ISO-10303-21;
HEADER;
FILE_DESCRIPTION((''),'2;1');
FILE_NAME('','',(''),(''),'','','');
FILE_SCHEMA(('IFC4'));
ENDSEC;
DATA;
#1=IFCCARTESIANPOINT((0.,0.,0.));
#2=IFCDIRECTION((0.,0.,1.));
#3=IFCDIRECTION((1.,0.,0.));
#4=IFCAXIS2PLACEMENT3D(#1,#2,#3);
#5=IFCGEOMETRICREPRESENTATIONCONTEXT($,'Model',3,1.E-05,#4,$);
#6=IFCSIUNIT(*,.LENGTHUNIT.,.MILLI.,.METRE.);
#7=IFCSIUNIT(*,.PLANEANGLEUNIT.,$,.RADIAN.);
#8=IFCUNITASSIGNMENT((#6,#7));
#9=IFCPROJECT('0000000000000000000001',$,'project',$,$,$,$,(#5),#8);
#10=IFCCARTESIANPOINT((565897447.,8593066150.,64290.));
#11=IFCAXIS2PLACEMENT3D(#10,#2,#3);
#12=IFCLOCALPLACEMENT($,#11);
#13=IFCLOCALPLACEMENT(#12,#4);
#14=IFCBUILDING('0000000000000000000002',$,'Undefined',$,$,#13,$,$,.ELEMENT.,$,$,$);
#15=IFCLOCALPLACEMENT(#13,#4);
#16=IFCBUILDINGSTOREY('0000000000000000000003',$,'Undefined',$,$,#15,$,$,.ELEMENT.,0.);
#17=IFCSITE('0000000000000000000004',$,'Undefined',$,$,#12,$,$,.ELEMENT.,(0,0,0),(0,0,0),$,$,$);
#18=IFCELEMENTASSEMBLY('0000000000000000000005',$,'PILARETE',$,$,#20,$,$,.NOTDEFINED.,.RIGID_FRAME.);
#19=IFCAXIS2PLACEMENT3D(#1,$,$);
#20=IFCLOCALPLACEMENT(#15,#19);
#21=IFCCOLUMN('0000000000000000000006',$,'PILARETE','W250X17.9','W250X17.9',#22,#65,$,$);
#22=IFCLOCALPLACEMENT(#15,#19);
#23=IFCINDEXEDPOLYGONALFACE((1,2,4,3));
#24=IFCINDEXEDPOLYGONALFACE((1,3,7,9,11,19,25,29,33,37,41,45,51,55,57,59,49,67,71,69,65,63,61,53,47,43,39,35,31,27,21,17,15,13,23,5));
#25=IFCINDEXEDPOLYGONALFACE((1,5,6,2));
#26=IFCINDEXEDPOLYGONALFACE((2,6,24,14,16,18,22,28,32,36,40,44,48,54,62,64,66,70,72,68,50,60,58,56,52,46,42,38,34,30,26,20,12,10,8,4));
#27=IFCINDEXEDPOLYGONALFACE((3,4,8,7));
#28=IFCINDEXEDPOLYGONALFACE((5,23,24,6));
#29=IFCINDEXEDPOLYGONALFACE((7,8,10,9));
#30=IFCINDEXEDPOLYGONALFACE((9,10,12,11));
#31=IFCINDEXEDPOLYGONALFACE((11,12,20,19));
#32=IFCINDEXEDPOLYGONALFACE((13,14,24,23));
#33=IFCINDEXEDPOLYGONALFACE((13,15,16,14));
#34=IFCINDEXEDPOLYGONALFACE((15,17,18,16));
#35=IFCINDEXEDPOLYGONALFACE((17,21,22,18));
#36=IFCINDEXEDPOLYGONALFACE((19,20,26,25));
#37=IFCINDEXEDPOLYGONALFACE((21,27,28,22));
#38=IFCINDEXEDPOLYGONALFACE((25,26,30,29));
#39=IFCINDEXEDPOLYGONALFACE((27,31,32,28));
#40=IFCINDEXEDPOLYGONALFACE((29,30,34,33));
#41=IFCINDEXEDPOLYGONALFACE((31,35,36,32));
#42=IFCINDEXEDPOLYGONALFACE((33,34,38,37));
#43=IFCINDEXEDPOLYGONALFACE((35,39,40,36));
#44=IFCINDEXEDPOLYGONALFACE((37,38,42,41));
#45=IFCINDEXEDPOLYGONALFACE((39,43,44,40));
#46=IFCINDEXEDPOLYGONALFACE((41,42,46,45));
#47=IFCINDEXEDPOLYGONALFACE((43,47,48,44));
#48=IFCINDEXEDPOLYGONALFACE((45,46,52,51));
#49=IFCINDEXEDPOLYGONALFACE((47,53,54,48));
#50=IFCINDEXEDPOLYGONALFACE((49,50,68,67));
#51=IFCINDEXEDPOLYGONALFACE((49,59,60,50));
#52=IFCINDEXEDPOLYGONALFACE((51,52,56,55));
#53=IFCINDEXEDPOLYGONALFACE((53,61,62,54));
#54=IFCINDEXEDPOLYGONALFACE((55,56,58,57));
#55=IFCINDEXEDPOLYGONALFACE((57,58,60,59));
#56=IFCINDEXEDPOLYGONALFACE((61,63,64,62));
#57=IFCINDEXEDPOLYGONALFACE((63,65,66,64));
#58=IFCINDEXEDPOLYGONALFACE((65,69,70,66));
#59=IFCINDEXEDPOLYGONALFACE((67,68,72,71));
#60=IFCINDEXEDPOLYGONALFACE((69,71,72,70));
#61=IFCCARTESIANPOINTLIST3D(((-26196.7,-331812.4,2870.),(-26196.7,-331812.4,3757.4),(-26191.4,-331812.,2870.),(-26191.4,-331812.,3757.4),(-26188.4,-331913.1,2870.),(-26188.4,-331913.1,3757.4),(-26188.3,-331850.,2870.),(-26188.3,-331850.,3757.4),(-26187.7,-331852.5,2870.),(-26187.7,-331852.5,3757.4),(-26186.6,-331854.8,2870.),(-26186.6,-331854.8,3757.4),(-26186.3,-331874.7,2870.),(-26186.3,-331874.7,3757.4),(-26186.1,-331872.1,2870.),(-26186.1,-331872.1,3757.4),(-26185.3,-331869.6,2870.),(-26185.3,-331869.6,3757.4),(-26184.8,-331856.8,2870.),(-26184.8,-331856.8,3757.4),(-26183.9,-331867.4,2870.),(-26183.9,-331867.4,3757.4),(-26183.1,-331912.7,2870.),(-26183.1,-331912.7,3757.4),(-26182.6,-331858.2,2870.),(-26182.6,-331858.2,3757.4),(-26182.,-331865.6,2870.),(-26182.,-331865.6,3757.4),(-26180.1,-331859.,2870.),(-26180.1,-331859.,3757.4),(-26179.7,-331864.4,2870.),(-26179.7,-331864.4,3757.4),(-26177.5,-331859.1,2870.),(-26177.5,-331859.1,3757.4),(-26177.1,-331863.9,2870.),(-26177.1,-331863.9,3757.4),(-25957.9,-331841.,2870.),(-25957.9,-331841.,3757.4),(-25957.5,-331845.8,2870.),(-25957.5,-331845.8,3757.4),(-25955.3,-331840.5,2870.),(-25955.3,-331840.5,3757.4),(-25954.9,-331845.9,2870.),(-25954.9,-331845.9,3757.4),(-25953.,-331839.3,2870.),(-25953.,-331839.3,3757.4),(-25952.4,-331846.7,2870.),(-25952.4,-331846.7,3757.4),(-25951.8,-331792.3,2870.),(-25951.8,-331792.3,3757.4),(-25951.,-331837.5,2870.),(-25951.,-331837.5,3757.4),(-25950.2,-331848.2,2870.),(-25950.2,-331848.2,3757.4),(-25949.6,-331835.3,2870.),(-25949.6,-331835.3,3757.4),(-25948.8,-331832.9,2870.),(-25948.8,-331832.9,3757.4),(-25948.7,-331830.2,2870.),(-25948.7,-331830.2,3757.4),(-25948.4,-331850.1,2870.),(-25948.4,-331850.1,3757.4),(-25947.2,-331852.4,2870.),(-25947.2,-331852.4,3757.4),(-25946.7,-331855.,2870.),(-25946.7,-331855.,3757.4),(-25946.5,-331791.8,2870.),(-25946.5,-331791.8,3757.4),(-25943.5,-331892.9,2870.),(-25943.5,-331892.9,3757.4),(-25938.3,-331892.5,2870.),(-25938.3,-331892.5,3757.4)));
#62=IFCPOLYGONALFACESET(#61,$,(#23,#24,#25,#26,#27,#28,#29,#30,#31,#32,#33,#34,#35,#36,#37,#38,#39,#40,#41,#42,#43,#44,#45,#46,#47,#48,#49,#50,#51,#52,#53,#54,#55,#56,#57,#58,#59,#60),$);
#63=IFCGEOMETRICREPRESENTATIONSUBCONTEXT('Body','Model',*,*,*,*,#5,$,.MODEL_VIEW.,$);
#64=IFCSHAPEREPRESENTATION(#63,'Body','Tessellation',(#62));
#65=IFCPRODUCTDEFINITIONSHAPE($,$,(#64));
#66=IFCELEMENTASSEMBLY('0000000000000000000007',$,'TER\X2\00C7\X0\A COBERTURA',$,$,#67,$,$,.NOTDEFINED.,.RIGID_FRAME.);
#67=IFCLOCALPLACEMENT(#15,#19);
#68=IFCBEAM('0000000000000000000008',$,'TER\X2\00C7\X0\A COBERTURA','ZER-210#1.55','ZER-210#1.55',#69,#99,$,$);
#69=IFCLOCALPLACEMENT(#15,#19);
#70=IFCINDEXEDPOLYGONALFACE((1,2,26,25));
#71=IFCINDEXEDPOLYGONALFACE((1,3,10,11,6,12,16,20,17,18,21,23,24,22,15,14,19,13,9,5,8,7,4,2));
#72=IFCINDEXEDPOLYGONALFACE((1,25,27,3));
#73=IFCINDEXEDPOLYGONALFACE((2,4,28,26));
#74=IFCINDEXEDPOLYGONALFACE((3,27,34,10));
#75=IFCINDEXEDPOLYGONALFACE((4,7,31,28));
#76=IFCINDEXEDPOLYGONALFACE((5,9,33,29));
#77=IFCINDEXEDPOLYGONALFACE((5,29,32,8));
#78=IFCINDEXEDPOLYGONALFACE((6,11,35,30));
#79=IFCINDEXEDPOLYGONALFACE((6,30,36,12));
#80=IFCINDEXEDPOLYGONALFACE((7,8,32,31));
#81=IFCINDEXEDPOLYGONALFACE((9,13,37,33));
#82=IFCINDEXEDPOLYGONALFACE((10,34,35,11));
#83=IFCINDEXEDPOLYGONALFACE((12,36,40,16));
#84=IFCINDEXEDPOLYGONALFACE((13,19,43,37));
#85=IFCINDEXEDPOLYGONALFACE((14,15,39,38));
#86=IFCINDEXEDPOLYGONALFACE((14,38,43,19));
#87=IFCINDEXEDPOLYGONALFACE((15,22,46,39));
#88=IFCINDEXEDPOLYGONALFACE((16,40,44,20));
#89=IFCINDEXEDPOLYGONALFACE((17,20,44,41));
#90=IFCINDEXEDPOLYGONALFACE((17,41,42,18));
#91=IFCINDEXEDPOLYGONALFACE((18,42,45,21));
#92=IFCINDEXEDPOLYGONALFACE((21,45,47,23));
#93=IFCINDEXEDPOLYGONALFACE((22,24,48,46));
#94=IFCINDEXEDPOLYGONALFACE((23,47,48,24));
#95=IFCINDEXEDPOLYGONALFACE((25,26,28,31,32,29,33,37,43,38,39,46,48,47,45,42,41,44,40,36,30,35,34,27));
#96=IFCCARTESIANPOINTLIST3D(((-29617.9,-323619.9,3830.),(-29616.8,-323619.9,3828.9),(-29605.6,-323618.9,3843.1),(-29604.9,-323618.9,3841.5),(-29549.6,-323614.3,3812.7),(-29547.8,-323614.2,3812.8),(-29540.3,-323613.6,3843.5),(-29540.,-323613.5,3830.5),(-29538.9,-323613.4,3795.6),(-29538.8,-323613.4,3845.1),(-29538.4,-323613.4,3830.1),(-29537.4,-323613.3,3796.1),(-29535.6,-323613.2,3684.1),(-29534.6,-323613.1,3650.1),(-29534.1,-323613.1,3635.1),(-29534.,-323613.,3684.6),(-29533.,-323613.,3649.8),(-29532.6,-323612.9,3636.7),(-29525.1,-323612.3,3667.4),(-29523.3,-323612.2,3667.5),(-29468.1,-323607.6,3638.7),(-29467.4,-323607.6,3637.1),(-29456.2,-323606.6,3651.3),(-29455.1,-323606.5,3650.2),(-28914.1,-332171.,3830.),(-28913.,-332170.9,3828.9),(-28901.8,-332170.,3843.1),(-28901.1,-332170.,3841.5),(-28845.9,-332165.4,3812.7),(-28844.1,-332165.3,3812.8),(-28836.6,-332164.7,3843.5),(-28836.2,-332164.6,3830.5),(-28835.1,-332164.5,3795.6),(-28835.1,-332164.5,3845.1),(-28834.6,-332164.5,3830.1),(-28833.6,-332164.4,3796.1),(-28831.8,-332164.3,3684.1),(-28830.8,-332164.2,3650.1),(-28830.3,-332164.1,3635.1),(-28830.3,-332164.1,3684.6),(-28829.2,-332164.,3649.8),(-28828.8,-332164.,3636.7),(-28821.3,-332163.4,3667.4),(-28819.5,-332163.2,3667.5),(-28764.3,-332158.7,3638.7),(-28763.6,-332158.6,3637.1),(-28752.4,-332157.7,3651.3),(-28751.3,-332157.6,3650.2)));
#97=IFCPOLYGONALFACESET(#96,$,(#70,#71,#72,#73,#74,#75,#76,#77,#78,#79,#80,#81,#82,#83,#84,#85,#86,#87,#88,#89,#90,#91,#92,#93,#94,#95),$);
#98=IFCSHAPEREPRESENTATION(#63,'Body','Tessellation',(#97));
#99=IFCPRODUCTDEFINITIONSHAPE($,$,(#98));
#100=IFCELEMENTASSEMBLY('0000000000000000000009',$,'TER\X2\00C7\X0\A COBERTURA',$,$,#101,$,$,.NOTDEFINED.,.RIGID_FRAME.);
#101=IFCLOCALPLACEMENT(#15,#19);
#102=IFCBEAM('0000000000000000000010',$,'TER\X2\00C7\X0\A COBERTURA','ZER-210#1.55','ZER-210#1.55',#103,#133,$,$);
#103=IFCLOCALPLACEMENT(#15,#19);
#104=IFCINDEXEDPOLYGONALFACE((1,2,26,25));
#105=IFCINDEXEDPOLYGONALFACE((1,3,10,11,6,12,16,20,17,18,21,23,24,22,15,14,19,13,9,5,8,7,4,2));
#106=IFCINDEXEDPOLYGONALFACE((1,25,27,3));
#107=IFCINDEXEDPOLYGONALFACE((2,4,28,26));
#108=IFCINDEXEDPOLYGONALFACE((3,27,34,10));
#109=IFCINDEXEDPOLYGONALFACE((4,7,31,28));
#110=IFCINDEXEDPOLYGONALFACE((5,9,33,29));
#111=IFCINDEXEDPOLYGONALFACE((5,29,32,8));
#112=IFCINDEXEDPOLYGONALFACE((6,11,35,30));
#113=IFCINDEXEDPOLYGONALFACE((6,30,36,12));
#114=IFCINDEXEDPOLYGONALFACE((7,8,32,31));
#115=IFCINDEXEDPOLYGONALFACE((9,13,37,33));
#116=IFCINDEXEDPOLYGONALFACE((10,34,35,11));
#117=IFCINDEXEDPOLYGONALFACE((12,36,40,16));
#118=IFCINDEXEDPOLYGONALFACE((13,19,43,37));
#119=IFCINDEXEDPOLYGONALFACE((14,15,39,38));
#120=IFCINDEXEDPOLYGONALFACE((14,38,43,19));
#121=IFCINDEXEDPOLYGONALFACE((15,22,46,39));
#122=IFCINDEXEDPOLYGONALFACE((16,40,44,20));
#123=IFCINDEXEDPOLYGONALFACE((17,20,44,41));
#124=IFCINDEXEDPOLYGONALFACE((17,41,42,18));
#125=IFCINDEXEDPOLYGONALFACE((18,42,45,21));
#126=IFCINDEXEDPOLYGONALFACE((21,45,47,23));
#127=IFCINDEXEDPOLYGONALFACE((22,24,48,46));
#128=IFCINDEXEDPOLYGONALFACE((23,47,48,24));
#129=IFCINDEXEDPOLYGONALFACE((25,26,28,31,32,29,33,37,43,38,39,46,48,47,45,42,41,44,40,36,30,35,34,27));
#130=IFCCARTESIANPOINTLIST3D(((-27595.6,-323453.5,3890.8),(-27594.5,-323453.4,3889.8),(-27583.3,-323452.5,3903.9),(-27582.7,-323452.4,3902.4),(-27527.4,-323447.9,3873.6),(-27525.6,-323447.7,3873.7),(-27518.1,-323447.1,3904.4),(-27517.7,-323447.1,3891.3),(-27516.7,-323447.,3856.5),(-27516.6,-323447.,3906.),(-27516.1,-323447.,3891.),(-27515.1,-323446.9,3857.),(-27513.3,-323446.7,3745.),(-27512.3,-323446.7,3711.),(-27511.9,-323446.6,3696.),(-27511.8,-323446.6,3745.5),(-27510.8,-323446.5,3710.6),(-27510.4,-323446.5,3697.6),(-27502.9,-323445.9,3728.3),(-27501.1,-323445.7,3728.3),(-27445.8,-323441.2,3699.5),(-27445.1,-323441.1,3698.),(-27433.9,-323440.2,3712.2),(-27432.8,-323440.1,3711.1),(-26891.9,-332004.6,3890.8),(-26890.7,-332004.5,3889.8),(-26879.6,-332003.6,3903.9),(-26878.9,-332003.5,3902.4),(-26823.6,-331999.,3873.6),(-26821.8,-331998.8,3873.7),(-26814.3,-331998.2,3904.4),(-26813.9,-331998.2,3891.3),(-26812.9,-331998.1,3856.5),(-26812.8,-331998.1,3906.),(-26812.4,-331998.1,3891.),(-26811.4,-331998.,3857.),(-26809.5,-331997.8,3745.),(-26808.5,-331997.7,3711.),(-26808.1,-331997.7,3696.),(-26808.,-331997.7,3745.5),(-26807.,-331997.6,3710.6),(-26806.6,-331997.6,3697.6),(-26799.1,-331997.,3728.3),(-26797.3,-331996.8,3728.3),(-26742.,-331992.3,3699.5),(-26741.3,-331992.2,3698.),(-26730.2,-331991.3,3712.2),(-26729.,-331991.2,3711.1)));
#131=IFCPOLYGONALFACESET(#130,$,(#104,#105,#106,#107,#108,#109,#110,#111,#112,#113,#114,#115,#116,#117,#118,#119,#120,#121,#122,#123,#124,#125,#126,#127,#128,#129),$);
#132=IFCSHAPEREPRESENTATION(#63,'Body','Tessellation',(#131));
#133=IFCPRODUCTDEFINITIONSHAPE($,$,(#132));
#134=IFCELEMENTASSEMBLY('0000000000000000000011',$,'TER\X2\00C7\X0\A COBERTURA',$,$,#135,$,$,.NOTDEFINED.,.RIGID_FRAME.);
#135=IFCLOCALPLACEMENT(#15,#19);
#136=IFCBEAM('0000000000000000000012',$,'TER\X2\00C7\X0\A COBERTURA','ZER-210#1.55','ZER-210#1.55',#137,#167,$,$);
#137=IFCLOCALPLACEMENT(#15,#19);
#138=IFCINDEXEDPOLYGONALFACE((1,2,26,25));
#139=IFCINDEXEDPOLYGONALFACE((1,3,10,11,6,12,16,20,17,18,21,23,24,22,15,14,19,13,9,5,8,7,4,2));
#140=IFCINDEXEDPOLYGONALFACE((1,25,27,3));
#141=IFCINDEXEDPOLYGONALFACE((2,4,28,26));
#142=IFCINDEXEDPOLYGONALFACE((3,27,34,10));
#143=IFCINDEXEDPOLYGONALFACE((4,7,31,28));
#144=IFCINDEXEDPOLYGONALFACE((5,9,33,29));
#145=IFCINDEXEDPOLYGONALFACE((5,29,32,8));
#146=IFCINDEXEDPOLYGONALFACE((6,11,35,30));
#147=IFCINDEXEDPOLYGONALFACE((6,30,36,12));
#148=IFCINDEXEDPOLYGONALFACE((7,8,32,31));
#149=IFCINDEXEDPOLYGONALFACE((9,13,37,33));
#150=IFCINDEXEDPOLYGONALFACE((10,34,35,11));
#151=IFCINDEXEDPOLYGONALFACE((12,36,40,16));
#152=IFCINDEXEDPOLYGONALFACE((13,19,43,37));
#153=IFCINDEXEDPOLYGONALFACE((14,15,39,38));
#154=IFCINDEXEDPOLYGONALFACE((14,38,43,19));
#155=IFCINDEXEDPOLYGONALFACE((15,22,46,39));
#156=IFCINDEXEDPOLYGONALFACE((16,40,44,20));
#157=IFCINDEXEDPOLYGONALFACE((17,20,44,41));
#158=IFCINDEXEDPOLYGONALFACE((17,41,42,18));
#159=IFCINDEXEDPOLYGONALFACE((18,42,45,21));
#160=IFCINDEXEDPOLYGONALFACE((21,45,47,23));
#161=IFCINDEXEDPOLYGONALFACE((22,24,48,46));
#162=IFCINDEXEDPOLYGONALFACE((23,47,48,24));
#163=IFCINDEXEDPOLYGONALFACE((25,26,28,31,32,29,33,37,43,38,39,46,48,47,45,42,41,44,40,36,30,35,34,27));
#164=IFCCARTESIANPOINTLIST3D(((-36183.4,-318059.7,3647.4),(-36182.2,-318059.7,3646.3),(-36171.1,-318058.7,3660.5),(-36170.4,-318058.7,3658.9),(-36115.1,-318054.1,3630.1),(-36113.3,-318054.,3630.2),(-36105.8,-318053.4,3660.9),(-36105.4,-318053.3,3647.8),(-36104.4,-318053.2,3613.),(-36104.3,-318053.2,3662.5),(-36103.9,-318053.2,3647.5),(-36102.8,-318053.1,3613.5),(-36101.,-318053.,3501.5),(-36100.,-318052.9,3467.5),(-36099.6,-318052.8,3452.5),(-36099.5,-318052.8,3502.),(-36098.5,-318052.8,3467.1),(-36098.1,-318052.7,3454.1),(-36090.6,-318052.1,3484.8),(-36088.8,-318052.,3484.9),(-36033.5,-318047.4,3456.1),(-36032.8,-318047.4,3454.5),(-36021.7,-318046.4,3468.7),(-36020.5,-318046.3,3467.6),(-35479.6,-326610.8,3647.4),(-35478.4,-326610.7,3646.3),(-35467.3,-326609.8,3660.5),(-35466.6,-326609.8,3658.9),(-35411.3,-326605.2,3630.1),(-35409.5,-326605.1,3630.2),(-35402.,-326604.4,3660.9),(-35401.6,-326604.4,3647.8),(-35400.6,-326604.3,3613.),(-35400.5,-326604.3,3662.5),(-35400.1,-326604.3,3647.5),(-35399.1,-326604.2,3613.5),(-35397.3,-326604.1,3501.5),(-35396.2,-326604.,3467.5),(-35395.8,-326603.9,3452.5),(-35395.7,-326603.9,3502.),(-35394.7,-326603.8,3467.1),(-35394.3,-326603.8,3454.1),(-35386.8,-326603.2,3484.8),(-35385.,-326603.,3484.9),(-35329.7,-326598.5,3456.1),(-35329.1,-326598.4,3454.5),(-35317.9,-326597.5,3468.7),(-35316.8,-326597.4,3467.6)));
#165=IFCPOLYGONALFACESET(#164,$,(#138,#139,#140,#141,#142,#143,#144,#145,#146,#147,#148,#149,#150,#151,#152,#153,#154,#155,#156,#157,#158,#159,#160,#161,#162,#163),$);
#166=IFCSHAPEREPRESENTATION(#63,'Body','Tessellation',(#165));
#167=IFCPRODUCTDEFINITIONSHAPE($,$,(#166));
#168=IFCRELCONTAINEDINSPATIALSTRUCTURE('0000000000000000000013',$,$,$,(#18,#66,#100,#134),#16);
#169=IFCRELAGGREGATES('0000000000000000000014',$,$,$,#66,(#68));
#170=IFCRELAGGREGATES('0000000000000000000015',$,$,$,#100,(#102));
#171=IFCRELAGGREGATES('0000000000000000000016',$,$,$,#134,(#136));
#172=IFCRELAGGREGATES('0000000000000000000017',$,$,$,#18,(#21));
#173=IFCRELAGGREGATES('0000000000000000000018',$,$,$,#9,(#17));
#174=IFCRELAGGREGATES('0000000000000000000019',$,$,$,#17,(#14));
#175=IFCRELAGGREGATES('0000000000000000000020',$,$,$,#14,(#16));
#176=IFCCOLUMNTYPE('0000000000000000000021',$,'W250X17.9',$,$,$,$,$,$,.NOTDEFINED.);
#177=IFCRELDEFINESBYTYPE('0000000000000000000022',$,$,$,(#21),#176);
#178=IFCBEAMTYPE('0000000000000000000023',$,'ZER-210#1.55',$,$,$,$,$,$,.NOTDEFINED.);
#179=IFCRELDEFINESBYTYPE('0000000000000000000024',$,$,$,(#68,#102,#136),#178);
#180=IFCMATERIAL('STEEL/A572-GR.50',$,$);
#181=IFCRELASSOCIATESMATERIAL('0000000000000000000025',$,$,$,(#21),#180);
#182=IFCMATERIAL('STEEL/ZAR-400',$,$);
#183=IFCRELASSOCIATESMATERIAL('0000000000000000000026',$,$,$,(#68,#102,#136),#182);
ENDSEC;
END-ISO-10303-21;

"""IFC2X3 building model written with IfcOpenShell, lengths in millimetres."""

from ifc_helpers import new_model, si_unit, frame, origin_with_axes, origin_2d_with_axis, place, context, subcontext, project, spatial, polyline, i_section, outline, extrude, material, type_object, element, aggregate, save


model = new_model("IFC2X3")

# Units and contexts
model_context = context("Model", 3, precision=1e-05, world=origin_with_axes())
body_context = subcontext(model_context, "Body", "Model", "MODEL_VIEW")
ifc_project = project(units=[si_unit("LENGTHUNIT", "METRE", prefix="MILLI"), si_unit("PLANEANGLEUNIT", "RADIAN")], contexts=[model_context])

# Site, building, storey
site_placement = place(None, frame((565897447.0, 8593066150.0, 64290.0), z_axis=(0.0, 0.0, 1.0), x_axis=(1.0, 0.0, 0.0)))
site = spatial("IfcSite", under=ifc_project, at=site_placement, Name="Undefined", CompositionType="ELEMENT", RefLatitude=(0, 0, 0), RefLongitude=(0, 0, 0))
building_placement = place(site_placement, origin_with_axes())
building = spatial("IfcBuilding", under=site, at=building_placement, Name="Undefined", CompositionType="ELEMENT")
storey_placement = place(building_placement, origin_with_axes())
storey = spatial("IfcBuildingStorey", under=building, at=storey_placement, Name="Undefined", CompositionType="ELEMENT", Elevation=0.0)

# Element assembly, column
assembly_1_placement = place(storey_placement, origin_with_axes())
assembly_1 = element("IfcElementAssembly", 1, at=assembly_1_placement, inside=storey, Name="PILARETE", AssemblyPlace="NOTDEFINED", PredefinedType="RIGID_FRAME")
ifc_material_1 = material(Name="STEEL/A572-GR.50")
column_type = type_object("IfcColumnType", Name="W250X17.9", PredefinedType="NOTDEFINED")
column_placement = place(assembly_1_placement, frame((-26067.5, -331852.5, 2870.0), z_axis=(0.0, 0.0, 1.0), x_axis=(-0.99663, -0.082025, 0.0)))
column = element("IfcColumn", 2, at=column_placement, type_object=column_type, material=ifc_material_1, Name="PILARETE", Description="W250X17.9", ObjectType="W250X17.9", context=body_context, shape_type="SweptSolid", body=[
    extrude(i_section(OverallWidth=101.0, OverallDepth=251.0, WebThickness=4.8, FlangeThickness=5.3, FilletRadius=10.0, at=origin_2d_with_axis()), frame((0.0, 0.0, 887.4), z_axis=(0.0, 0.0, -1.0), x_axis=(0.0, 1.0, 0.0)), (0.0, 0.0, 1.0), 887.4),
])

# Element assemblies, beams
assembly_2_placement = place(storey_placement, origin_with_axes())
assembly_2 = element("IfcElementAssembly", 3, at=assembly_2_placement, inside=storey, Name="TERÇA COBERTURA", AssemblyPlace="NOTDEFINED", PredefinedType="RIGID_FRAME")
ifc_material_2 = material(Name="STEEL/ZAR-400")
beam_type_1 = type_object("IfcBeamType", Name="ZER-210#1.55", PredefinedType="NOTDEFINED")
beam_1_placement = place(assembly_2_placement, frame((-28832.7, -332164.3, 3740.1), z_axis=(-0.029885, -0.00246, 0.99955), x_axis=(-0.082025, 0.99663, 0.0)))
beam_1 = element("IfcBeam", 4, at=beam_1_placement, type_object=beam_type_1, material=ifc_material_2, Name="TERÇA COBERTURA", Description="ZER-210#1.55", ObjectType="ZER-210#1.55", context=body_context, shape_type="SweptSolid", body=[
    extrude(outline(polyline([(65.6, -103.4), (77.9, -91.2), (79.0, -92.3), (66.2, -105.0), (-0.8, -105.0), (-0.8, -90.0), (9.2, -73.0), (-0.8, -56.0), (-0.8, 55.6), (-11.0, 73.0), (-0.8, 90.4), (-0.8, 103.5), (-65.6, 103.4), (-77.9, 91.2), (-79.0, 92.3), (-66.2, 105.0), (0.8, 105.0), (0.8, 90.0), (-9.2, 73.0), (0.8, 56.0), (0.8, -55.6), (11.0, -73.0), (0.8, -90.4), (0.8, -103.5), (65.6, -103.4)])), frame((8580.0, 0.0, 0.0), z_axis=(-1.0, 0.0, 0.0), x_axis=(0.0, -1.0, 0.0)), (0.0, 0.0, 1.0), 8580.0),
])
aggregate(assembly_2, [beam_1])
assembly_3_placement = place(storey_placement, origin_with_axes())
assembly_3 = element("IfcElementAssembly", 5, at=assembly_3_placement, inside=storey, Name="TERÇA COBERTURA", AssemblyPlace="NOTDEFINED", PredefinedType="RIGID_FRAME")
beam_2_placement = place(assembly_3_placement, frame((-26810.4, -331997.9, 3801.0), z_axis=(-0.029885, -0.00246, 0.99955), x_axis=(-0.082025, 0.99663, 0.0)))
beam_2 = element("IfcBeam", 6, at=beam_2_placement, type_object=beam_type_1, material=ifc_material_2, Name="TERÇA COBERTURA", Description="ZER-210#1.55", ObjectType="ZER-210#1.55", context=body_context, shape_type="SweptSolid", body=[
    extrude(outline(polyline([(65.6, -103.4), (77.9, -91.2), (79.0, -92.3), (66.2, -105.0), (-0.8, -105.0), (-0.8, -90.0), (9.2, -73.0), (-0.8, -56.0), (-0.8, 55.6), (-11.0, 73.0), (-0.8, 90.4), (-0.8, 103.5), (-65.6, 103.4), (-77.9, 91.2), (-79.0, 92.3), (-66.2, 105.0), (0.8, 105.0), (0.8, 90.0), (-9.2, 73.0), (0.8, 56.0), (0.8, -55.6), (11.0, -73.0), (0.8, -90.4), (0.8, -103.5), (65.6, -103.4)])), frame((8580.0, 0.0, 0.0), z_axis=(-1.0, 0.0, 0.0), x_axis=(0.0, -1.0, 0.0)), (0.0, 0.0, 1.0), 8580.0),
])
aggregate(assembly_3, [beam_2])
assembly_4_placement = place(storey_placement, origin_with_axes())
assembly_4 = element("IfcElementAssembly", 7, at=assembly_4_placement, inside=storey, Name="TERÇA COBERTURA", AssemblyPlace="NOTDEFINED", PredefinedType="RIGID_FRAME")
beam_3_placement = place(assembly_4_placement, frame((-35398.2, -326604.1, 3557.5), z_axis=(-0.029885, -0.00246, 0.99955), x_axis=(-0.082025, 0.99663, 0.0)))
beam_3 = element("IfcBeam", 8, at=beam_3_placement, type_object=beam_type_1, material=ifc_material_2, Name="TERÇA COBERTURA", Description="ZER-210#1.55", ObjectType="ZER-210#1.55", context=body_context, shape_type="SweptSolid", body=[
    extrude(outline(polyline([(65.6, -103.4), (77.9, -91.2), (79.0, -92.3), (66.2, -105.0), (-0.8, -105.0), (-0.8, -90.0), (9.2, -73.0), (-0.8, -56.0), (-0.8, 55.6), (-11.0, 73.0), (-0.8, 90.4), (-0.8, 103.5), (-65.6, 103.4), (-77.9, 91.2), (-79.0, 92.3), (-66.2, 105.0), (0.8, 105.0), (0.8, 90.0), (-9.2, 73.0), (0.8, 56.0), (0.8, -55.6), (11.0, -73.0), (0.8, -90.4), (0.8, -103.5), (65.6, -103.4)])), frame((8580.0, 0.0, 0.0), z_axis=(-1.0, 0.0, 0.0), x_axis=(0.0, -1.0, 0.0)), (0.0, 0.0, 1.0), 8580.0),
])
aggregate(assembly_4, [beam_3])

aggregate(assembly_1, [column])

save(model, "model.ifc")
